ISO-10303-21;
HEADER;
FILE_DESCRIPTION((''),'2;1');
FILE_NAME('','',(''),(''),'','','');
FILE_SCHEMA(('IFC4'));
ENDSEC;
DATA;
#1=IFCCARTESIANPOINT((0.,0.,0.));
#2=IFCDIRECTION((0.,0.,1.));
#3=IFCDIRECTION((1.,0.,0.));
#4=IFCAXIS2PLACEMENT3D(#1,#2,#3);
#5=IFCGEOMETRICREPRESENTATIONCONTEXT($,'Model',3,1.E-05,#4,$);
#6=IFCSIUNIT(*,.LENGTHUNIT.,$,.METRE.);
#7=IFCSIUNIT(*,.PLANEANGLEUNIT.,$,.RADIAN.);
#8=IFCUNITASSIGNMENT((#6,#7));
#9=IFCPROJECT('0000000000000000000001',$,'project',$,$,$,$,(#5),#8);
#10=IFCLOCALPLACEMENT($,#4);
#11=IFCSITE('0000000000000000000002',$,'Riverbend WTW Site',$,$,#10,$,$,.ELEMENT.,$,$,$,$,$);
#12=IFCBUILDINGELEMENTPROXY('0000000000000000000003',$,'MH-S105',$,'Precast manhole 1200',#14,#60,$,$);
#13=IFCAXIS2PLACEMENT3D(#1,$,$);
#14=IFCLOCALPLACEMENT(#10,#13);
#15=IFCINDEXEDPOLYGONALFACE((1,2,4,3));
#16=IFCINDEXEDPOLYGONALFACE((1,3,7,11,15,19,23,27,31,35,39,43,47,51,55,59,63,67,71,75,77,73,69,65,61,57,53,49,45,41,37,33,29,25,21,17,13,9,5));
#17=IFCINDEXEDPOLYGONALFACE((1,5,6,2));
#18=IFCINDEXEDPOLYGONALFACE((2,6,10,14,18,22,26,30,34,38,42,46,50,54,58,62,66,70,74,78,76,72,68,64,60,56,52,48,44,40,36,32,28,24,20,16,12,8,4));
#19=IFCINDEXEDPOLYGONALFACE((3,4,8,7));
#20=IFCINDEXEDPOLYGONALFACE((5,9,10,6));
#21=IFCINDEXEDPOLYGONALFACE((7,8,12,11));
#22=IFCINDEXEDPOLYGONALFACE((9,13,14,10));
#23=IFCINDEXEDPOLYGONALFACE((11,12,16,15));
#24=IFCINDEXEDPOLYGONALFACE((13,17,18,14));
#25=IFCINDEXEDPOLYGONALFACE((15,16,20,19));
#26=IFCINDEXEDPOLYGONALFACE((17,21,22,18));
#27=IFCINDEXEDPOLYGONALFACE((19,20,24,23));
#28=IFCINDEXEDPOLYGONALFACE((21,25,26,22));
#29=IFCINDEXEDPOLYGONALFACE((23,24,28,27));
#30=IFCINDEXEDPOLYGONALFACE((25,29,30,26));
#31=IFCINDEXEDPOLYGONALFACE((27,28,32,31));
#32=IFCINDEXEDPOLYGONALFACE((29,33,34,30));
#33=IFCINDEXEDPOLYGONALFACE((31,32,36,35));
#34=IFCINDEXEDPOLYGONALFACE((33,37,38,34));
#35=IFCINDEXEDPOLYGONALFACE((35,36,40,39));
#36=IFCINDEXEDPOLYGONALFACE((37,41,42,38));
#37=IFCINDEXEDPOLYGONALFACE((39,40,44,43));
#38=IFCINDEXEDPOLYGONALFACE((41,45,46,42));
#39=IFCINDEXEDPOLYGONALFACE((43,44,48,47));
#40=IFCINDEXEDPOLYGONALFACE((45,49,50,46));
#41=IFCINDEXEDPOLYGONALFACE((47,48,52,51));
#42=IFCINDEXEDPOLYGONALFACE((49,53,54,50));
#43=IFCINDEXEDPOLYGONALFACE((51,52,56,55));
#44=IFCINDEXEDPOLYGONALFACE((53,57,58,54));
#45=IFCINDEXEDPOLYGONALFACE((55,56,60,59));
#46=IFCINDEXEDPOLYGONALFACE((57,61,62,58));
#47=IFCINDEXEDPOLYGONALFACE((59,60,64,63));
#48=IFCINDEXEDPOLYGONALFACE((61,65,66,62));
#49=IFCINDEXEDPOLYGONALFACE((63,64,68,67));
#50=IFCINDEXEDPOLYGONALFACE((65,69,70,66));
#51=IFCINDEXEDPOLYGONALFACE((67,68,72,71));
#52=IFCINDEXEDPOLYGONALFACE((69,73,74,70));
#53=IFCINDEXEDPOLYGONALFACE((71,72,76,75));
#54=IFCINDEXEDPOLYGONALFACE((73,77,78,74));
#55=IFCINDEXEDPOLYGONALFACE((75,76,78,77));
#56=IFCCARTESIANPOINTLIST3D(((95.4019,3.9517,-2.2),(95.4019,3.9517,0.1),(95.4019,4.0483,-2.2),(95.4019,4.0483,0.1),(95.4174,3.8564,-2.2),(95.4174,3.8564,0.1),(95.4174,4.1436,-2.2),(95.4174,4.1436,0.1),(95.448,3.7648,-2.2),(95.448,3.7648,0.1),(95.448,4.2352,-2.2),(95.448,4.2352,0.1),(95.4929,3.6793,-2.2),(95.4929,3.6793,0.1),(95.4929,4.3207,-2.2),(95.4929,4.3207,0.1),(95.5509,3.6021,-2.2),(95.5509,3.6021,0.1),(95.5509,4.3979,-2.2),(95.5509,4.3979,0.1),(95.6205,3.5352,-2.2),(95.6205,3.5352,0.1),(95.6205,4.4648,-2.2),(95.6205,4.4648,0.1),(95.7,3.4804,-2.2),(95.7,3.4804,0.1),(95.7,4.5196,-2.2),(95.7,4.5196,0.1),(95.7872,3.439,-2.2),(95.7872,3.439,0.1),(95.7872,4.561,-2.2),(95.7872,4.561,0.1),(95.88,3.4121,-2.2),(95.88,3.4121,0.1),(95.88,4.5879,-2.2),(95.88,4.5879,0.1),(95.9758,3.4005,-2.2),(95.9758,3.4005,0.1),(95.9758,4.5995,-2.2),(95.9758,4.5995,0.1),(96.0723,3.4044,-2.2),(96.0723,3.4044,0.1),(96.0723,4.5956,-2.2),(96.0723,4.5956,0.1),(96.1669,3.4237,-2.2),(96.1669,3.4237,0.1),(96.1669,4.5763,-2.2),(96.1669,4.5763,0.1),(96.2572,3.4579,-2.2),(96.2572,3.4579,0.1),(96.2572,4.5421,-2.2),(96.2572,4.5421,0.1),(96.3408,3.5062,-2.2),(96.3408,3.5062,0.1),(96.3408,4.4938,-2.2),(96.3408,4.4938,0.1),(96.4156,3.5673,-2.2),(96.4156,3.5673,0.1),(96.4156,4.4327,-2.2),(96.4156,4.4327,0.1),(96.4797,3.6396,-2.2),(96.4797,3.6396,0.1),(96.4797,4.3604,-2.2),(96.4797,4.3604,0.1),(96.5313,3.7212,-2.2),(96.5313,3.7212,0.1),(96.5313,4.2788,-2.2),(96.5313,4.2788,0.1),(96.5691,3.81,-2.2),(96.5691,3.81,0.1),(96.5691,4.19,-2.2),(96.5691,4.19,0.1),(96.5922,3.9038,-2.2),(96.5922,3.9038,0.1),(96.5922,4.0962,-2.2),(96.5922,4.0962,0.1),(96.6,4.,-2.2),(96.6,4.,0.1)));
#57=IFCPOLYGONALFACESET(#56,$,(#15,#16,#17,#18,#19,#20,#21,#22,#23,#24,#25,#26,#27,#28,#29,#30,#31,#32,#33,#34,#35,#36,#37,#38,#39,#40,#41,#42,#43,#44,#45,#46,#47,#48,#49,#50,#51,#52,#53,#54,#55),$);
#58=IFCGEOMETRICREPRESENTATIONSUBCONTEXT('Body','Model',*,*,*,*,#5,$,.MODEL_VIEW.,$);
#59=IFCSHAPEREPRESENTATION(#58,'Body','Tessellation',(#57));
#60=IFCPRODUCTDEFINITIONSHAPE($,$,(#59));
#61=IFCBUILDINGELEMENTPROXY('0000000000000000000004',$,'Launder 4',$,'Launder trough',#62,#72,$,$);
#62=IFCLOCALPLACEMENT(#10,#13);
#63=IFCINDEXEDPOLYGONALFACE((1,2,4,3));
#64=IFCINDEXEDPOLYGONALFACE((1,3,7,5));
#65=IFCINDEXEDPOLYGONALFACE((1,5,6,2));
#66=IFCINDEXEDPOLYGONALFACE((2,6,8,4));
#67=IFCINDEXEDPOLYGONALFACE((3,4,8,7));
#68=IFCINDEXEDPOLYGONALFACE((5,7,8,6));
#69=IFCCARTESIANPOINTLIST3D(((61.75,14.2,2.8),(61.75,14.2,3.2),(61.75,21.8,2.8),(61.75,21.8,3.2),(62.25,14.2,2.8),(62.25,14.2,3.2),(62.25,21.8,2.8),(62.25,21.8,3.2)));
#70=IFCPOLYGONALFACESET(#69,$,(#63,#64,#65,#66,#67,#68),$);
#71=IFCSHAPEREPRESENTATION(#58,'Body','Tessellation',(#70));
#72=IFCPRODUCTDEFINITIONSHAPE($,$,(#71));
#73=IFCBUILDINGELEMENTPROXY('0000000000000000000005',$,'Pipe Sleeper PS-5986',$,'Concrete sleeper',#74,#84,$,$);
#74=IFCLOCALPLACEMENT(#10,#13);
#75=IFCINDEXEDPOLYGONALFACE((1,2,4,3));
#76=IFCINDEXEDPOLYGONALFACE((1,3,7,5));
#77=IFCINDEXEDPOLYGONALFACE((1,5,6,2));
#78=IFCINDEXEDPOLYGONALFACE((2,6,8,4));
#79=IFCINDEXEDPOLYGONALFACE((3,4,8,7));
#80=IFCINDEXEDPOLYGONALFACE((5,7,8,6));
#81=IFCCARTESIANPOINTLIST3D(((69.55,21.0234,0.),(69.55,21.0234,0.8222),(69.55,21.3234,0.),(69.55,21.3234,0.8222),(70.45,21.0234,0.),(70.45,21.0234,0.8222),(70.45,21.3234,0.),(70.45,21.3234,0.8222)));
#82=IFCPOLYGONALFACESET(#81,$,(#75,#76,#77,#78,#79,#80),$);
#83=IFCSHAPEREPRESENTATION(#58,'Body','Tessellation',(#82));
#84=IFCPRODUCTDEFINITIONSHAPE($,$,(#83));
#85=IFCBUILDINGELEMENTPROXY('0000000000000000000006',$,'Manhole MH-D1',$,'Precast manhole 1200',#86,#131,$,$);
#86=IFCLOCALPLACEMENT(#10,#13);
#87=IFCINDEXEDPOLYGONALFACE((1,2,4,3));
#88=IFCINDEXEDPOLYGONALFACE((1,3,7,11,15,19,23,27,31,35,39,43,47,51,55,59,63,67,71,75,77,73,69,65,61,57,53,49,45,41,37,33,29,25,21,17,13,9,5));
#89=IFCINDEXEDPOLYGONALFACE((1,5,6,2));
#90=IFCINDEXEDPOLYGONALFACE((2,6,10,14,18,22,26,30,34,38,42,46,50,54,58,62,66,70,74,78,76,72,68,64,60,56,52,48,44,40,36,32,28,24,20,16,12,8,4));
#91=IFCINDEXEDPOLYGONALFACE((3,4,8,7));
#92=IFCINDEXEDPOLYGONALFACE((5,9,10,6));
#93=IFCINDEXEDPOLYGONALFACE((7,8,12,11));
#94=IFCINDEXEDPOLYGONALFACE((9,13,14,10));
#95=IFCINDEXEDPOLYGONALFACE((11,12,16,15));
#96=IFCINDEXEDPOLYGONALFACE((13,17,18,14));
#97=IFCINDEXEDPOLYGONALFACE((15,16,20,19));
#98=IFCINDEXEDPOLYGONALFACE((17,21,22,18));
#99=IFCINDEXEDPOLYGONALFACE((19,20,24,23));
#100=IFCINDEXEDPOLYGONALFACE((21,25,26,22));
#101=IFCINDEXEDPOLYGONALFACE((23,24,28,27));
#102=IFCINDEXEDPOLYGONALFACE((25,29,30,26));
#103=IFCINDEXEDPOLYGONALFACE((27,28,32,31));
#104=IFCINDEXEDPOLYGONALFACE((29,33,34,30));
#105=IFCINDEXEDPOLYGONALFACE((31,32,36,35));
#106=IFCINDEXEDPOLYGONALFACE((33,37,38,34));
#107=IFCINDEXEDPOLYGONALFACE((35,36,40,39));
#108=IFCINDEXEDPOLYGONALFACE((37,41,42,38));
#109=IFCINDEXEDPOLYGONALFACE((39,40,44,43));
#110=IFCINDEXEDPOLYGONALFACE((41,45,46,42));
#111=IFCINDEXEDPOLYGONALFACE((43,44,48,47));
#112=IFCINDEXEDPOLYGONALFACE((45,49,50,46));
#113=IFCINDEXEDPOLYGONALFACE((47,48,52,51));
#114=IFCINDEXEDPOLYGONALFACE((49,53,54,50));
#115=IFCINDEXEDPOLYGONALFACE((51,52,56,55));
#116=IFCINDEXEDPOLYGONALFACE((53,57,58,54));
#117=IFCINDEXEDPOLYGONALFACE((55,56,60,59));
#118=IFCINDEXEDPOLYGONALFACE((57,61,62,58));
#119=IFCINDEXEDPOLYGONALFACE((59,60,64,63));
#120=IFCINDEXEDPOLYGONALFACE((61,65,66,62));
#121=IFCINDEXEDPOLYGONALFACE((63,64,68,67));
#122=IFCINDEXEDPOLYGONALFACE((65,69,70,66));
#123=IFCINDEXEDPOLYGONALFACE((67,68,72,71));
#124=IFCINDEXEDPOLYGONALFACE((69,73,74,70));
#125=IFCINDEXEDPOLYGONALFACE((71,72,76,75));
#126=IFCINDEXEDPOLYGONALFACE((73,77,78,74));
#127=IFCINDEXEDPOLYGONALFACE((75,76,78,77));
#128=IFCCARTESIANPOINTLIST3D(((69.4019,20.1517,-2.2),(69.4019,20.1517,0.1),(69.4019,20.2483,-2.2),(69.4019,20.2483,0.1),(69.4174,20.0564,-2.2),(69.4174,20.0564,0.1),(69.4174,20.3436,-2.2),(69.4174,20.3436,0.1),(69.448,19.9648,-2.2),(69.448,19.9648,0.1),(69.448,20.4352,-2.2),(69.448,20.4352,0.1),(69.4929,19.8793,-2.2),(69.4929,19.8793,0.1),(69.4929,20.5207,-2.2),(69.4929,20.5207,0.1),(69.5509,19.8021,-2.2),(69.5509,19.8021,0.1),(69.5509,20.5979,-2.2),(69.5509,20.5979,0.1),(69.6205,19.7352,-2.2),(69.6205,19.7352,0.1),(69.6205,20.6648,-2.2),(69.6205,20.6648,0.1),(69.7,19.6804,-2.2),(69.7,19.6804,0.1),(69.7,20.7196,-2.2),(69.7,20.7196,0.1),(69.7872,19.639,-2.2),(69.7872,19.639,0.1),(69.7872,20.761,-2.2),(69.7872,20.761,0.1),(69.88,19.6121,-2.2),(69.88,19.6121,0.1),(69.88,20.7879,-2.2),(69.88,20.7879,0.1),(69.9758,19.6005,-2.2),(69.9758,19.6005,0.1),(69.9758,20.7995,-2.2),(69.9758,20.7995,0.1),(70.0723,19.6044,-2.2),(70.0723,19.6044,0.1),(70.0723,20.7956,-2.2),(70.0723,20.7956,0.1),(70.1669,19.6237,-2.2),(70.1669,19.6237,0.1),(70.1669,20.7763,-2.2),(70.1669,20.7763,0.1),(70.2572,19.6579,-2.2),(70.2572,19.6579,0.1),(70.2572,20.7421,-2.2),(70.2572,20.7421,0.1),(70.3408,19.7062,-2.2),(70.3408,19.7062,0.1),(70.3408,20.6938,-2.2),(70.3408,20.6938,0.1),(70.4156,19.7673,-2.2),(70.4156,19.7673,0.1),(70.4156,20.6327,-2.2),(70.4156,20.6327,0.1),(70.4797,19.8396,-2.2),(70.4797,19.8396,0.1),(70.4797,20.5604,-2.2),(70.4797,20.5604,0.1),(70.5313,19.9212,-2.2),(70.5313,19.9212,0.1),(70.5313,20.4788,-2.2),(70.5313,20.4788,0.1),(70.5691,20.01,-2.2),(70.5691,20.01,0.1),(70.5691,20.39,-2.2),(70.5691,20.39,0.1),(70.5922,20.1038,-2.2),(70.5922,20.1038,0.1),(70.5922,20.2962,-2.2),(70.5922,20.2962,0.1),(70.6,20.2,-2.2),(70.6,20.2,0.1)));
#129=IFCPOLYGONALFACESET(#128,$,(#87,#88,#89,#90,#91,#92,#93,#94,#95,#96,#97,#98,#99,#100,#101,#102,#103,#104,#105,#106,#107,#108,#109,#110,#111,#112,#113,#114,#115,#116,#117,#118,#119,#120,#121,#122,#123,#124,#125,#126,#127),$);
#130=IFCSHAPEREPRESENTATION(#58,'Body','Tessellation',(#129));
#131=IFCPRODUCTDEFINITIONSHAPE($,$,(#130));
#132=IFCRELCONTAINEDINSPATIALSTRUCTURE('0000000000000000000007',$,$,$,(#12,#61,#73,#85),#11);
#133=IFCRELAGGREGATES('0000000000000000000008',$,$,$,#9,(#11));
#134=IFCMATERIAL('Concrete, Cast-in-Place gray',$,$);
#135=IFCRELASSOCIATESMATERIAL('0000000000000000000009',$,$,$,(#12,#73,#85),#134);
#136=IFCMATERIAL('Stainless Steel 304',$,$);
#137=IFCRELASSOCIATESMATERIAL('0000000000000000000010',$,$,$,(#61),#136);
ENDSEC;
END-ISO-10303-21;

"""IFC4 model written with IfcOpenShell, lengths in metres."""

from ifc_helpers import new_model, si_unit, frame, origin_with_axes, origin_2d, place, context, subcontext, project, spatial, rectangle, circle, extrude, material, element, save


model = new_model("IFC4")

# Units and contexts
model_context = context("Model", 3, precision=1e-05, world=origin_with_axes())
body_context = subcontext(model_context, "Body", "Model", "MODEL_VIEW")
ifc_project = project(units=[si_unit("LENGTHUNIT", "METRE"), si_unit("PLANEANGLEUNIT", "RADIAN")], contexts=[model_context])

# Site
site_placement = place(None, origin_with_axes())
site = spatial("IfcSite", under=ifc_project, at=site_placement, Name="Riverbend WTW Site", CompositionType="ELEMENT")

# Shared definitions
ifc_material_1 = material(Name="Concrete, Cast-in-Place gray")

# Building element proxies
for number, where, z_axis, x_axis, name in (
    (1, (96.0, 4.0, -2.2), (0.0, 0.0, 1.0), (1.0, 0.0, 0.0), "MH-S105"),
):
    element("IfcBuildingElementProxy", number, at=place(None, frame(where, z_axis=z_axis, x_axis=x_axis)), inside=site, material=ifc_material_1, Name=name, ObjectType="Precast manhole 1200", context=body_context, shape_type="SweptSolid", body=[
        extrude(circle(Radius=0.6, at=origin_2d()), origin_with_axes(), (0.0, 0.0, 1.0), 2.3),
    ])
ifc_material_2 = material(Name="Stainless Steel 304")
proxy_1_placement = place(None, frame((62.0, 18.0, 3.0), z_axis=(0.0, 0.0, 1.0), x_axis=(1.0, 0.0, 0.0)))
element("IfcBuildingElementProxy", 2, at=proxy_1_placement, inside=site, material=ifc_material_2, Name="Launder 4", ObjectType="Launder trough", context=body_context, shape_type="SweptSolid", body=[
    extrude(rectangle(XDim=0.5, YDim=7.6, at=origin_2d()), frame((0.0, 0.0, -0.2), z_axis=(0.0, 0.0, 1.0), x_axis=(1.0, 0.0, 0.0)), (0.0, 0.0, 1.0), 0.4),
])
proxy_2_placement = place(None, frame((70.0, 21.1734, 0.4111), z_axis=(0.0, 0.0, 1.0), x_axis=(1.0, 0.0, 0.0)))
element("IfcBuildingElementProxy", 3, at=proxy_2_placement, inside=site, material=ifc_material_1, Name="Pipe Sleeper PS-5986", ObjectType="Concrete sleeper", context=body_context, shape_type="SweptSolid", body=[
    extrude(rectangle(XDim=0.9, YDim=0.3, at=origin_2d()), frame((0.0, 0.0, -0.4111), z_axis=(0.0, 0.0, 1.0), x_axis=(1.0, 0.0, 0.0)), (0.0, 0.0, 1.0), 0.8222),
])
proxy_3_placement = place(None, frame((70.0, 20.2, -2.2), z_axis=(0.0, 0.0, 1.0), x_axis=(1.0, 0.0, 0.0)))
element("IfcBuildingElementProxy", 4, at=proxy_3_placement, inside=site, material=ifc_material_1, Name="Manhole MH-D1", ObjectType="Precast manhole 1200", context=body_context, shape_type="SweptSolid", body=[
    extrude(circle(Radius=0.6, at=origin_2d()), origin_with_axes(), (0.0, 0.0, 1.0), 2.3),
])

save(model, "model.ifc")
